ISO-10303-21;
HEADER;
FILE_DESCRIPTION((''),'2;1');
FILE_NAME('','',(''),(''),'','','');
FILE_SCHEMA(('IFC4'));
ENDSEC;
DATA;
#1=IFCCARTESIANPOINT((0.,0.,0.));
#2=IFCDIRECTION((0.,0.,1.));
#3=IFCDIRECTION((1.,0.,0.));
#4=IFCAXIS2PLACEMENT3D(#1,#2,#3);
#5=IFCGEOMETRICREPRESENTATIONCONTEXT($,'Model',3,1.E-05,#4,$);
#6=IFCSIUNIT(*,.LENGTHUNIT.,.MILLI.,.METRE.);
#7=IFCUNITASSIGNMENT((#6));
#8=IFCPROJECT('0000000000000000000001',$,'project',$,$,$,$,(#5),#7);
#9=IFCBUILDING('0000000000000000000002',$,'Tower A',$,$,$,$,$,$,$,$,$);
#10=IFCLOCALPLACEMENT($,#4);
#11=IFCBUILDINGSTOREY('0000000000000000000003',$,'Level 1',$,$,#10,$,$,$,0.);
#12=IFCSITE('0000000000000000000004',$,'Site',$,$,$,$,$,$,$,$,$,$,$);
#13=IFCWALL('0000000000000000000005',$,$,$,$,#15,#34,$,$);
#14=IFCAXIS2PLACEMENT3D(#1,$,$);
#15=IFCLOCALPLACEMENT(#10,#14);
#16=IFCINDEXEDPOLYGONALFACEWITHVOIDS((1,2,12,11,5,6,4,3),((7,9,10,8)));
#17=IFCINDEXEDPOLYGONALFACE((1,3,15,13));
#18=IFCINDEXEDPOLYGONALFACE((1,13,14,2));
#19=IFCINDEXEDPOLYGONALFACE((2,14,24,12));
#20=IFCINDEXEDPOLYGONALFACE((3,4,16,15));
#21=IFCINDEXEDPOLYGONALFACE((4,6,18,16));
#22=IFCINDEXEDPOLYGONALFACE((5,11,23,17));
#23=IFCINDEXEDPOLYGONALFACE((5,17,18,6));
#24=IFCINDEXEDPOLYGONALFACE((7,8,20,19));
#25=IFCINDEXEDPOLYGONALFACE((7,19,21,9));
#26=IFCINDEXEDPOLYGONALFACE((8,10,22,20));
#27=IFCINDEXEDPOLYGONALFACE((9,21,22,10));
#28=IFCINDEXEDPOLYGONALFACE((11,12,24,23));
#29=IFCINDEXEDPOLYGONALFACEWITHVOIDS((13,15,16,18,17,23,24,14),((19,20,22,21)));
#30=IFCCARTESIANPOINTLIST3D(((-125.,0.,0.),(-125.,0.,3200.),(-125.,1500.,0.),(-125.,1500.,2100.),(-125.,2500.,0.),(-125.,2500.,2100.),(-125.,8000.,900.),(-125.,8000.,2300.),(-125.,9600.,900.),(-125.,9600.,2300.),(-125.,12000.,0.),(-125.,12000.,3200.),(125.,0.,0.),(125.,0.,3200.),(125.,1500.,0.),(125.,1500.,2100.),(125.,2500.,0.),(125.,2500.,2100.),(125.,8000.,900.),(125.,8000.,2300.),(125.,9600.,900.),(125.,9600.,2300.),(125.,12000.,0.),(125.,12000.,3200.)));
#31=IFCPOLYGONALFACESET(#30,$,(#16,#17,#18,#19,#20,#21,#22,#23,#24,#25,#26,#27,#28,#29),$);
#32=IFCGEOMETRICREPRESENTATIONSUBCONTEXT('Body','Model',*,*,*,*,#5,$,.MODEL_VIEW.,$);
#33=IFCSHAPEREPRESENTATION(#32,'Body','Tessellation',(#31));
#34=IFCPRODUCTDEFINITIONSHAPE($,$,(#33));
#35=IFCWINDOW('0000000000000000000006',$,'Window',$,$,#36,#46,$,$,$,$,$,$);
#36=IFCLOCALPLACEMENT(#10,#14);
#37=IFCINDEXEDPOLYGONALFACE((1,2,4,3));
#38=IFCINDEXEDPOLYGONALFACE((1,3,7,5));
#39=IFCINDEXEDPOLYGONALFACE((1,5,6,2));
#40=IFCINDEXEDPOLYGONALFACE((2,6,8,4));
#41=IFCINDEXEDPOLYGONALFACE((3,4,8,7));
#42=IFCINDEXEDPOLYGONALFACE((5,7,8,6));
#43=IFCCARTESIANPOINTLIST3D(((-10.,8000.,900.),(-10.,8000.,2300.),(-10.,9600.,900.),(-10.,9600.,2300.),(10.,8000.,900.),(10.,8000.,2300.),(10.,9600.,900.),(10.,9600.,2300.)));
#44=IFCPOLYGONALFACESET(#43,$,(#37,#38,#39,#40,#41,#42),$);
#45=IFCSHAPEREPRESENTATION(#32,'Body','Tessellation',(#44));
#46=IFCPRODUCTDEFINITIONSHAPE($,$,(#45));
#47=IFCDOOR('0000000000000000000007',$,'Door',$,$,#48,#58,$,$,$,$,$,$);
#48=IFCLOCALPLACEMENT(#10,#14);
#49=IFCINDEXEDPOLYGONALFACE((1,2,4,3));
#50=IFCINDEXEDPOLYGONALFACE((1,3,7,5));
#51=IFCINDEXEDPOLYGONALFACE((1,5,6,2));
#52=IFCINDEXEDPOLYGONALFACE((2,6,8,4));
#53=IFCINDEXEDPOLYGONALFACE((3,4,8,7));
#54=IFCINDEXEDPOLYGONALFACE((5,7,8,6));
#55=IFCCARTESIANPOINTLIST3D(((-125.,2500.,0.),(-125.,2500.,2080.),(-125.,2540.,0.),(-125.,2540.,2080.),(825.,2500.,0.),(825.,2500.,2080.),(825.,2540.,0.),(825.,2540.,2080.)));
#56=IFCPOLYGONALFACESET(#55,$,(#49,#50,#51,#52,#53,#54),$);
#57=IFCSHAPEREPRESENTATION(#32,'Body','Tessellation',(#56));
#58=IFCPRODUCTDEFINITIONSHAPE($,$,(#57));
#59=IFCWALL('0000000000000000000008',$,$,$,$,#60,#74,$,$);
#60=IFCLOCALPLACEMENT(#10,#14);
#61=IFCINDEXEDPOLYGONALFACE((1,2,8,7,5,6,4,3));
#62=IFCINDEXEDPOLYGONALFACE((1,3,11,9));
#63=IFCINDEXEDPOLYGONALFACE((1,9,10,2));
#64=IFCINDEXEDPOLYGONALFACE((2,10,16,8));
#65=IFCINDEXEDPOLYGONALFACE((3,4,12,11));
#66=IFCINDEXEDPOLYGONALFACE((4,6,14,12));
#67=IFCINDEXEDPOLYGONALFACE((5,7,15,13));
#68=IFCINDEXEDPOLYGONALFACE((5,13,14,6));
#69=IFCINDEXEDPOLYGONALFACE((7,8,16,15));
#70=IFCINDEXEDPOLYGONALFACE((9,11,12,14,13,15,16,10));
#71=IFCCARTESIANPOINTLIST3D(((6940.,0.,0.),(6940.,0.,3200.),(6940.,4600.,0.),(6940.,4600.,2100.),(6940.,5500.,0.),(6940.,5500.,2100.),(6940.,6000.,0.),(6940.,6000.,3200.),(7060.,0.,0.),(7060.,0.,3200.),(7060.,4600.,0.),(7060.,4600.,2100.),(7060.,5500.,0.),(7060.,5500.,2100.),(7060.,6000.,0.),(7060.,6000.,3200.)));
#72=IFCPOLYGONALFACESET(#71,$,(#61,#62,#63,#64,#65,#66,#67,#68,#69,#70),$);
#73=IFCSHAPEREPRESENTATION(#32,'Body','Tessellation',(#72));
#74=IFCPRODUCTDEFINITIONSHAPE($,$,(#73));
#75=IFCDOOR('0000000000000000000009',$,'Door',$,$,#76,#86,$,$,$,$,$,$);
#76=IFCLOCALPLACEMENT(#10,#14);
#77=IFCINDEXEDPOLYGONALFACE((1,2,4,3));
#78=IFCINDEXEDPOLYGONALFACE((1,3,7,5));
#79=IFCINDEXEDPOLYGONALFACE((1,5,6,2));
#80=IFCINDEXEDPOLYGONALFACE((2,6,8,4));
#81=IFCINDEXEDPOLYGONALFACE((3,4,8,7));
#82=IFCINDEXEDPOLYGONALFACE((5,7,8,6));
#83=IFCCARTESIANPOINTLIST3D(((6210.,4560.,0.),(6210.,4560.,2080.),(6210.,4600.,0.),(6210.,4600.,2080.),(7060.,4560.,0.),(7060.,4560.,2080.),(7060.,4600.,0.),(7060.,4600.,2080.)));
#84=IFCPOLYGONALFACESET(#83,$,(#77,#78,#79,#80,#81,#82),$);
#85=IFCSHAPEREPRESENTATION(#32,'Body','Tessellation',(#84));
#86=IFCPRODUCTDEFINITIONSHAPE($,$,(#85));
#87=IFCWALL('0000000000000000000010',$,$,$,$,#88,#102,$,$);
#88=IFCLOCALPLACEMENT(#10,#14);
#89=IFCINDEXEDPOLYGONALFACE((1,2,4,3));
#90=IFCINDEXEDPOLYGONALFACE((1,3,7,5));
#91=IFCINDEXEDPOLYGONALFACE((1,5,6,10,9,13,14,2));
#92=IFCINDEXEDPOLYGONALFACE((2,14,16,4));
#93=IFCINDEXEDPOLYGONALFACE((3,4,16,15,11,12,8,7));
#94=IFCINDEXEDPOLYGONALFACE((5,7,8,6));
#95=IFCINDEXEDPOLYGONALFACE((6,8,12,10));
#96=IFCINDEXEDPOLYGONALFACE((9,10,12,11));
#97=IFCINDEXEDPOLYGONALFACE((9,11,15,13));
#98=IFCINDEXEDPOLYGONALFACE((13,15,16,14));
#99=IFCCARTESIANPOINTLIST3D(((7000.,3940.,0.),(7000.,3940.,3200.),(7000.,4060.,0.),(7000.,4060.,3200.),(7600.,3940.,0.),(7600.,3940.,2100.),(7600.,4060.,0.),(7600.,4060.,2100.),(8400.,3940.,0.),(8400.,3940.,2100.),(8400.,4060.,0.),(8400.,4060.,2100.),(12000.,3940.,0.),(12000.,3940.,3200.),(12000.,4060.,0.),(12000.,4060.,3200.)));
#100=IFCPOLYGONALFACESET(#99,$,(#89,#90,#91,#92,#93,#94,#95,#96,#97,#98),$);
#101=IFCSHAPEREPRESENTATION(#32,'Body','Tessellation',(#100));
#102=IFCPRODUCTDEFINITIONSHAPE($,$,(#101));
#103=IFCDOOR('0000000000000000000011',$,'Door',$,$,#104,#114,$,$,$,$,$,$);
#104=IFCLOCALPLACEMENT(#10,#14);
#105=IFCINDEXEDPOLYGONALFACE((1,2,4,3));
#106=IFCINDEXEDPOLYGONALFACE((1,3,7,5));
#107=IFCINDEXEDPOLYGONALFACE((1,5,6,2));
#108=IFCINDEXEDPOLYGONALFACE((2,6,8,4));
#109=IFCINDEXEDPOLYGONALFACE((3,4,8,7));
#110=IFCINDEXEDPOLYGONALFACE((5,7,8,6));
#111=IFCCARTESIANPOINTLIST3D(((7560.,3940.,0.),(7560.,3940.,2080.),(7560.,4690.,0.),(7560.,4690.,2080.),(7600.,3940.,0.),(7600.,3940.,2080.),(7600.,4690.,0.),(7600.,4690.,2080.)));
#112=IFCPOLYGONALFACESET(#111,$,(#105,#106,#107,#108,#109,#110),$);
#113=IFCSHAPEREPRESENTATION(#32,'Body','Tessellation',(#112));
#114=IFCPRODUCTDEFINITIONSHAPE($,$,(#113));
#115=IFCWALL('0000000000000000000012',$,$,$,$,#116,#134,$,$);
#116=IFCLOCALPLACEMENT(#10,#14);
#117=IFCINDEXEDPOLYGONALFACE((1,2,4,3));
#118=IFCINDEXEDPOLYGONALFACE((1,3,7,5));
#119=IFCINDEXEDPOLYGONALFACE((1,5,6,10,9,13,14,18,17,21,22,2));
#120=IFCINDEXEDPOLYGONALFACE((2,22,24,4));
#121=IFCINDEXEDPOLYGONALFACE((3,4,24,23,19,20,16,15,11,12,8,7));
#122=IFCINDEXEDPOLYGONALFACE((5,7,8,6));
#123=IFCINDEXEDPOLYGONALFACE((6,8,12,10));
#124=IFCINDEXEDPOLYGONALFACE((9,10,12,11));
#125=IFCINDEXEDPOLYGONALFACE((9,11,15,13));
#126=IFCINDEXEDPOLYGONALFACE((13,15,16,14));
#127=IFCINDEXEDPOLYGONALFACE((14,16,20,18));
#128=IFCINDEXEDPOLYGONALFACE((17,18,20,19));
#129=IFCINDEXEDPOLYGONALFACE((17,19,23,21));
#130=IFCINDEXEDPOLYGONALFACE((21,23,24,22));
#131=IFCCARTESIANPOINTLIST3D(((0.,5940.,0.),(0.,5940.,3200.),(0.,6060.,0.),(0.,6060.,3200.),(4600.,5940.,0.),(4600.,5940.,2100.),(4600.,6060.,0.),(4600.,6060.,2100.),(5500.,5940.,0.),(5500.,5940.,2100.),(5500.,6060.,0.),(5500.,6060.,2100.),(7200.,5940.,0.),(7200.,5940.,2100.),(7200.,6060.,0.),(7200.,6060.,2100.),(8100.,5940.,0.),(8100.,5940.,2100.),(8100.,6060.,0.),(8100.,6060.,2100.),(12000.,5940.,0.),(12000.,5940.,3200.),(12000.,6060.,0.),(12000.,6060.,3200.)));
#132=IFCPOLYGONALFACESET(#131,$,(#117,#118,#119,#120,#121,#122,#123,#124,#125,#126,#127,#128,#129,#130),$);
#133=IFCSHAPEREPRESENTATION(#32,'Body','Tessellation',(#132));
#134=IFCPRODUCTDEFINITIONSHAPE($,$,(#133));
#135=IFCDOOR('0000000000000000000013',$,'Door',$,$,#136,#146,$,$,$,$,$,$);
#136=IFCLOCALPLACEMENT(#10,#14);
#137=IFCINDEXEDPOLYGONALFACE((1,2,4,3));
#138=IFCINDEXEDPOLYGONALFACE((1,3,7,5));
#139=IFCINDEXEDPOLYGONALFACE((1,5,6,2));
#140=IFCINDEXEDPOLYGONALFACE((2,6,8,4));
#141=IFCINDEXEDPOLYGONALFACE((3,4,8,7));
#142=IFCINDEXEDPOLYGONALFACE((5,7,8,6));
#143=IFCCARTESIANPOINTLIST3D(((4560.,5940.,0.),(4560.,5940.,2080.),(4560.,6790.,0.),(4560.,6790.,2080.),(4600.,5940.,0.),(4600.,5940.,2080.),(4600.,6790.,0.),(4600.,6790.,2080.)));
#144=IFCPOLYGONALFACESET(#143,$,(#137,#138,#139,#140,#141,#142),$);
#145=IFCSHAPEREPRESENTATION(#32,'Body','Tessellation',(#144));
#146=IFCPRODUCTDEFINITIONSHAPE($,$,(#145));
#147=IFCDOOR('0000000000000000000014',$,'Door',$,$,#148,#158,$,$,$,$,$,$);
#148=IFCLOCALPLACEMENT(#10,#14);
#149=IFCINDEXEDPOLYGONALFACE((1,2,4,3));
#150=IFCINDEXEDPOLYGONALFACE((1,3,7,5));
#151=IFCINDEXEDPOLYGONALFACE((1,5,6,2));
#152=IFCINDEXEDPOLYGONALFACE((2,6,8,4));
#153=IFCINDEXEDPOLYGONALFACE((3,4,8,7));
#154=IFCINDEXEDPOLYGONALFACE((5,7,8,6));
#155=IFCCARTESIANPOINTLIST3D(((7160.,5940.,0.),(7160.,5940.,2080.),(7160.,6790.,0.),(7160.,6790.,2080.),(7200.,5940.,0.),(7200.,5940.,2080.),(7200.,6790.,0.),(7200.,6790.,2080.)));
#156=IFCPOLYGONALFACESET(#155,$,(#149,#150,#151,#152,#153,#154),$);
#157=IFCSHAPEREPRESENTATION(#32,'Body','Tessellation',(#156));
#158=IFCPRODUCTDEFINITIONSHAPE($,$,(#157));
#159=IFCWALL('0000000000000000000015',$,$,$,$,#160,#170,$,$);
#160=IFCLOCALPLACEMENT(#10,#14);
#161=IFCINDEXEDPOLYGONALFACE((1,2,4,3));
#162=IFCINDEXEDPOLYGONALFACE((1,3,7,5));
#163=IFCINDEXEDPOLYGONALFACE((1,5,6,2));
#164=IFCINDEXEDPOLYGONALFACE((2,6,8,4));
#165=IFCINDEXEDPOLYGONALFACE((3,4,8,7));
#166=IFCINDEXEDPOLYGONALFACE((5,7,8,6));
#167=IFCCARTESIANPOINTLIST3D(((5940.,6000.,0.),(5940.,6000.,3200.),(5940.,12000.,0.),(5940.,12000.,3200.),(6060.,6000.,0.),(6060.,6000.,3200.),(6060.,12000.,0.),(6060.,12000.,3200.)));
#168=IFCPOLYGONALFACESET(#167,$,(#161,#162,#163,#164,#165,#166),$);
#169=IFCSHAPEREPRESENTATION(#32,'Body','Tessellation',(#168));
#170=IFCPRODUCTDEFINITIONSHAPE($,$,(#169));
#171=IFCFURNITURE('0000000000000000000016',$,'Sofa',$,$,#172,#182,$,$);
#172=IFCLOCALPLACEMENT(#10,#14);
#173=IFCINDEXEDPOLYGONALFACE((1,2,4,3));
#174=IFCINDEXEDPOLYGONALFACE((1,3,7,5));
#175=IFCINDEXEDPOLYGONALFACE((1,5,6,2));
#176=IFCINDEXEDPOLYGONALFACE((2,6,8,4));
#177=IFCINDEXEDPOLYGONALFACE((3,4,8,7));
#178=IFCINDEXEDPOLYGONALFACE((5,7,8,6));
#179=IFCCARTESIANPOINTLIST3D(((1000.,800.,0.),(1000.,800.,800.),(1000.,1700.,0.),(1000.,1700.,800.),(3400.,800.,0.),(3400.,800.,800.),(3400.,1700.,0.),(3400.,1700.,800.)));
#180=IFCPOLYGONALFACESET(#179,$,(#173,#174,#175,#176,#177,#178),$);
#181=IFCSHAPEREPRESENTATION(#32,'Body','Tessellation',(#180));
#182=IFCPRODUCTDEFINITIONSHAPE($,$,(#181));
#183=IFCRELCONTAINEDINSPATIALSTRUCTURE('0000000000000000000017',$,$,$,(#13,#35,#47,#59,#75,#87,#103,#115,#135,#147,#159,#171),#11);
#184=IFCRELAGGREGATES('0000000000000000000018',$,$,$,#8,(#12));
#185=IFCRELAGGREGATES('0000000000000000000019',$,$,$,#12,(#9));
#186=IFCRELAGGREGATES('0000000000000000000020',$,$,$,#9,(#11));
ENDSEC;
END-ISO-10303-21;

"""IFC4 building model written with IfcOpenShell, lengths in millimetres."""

from ifc_helpers import new_model, si_unit, frame, origin_with_axes, place, context, subcontext, project, spatial, indexed_curve, outline, extrude, element, fill, save


model = new_model("IFC4")

# Units and contexts
model_context = context("Model", 3, precision=1e-05, world=origin_with_axes())
body_context = subcontext(model_context, "Body", "Model", "MODEL_VIEW")
ifc_project = project(units=[si_unit("LENGTHUNIT", "METRE", prefix="MILLI")], contexts=[model_context])

# Site, building, storey
site = spatial("IfcSite", under=ifc_project, Name="Site")
building = spatial("IfcBuilding", under=site, Name="Tower A")
storey_placement = place(None, origin_with_axes())
storey = spatial("IfcBuildingStorey", under=building, at=storey_placement, Name="Level 1", Elevation=0.0)

# Wall, openings, window, door
wall_1_placement = place(storey_placement, frame((-125.0, 12000.0, 0.0), z_axis=(0.0, 0.0, 1.0), x_axis=(0.0, -1.0, 0.0)))
wall_1 = element("IfcWall", 1, at=wall_1_placement, inside=storey, context=body_context, shape_type="SweptSolid", body=[
    extrude(outline(indexed_curve([(0.0, 0.0), (0.0, 250.0), (12000.0, 250.0), (12000.0, 0.0), (0.0, 0.0)], self_intersect=False)), origin_with_axes(), (0.0, 0.0, 1.0), 3200.0),
])
opening_1_placement = place(wall_1_placement, frame((2400.0, 0.0, 900.0), z_axis=(0.0, 0.0, 1.0), x_axis=(1.0, 0.0, 0.0)))
opening_1 = element("IfcOpeningElement", 2, at=opening_1_placement, cuts=wall_1, context=body_context, shape_type="SweptSolid", body=[
    extrude(outline(indexed_curve([(0.0, 0.0), (0.0, 250.0), (1600.0, 250.0), (1600.0, 0.0), (0.0, 0.0)], self_intersect=False)), origin_with_axes(), (0.0, 0.0, 1.0), 1400.0),
])
opening_2_placement = place(wall_1_placement, frame((9500.0, 0.0, 0.0), z_axis=(0.0, 0.0, 1.0), x_axis=(1.0, 0.0, 0.0)))
opening_2 = element("IfcOpeningElement", 3, at=opening_2_placement, cuts=wall_1, context=body_context, shape_type="SweptSolid", body=[
    extrude(outline(indexed_curve([(0.0, 0.0), (0.0, 250.0), (1000.0, 250.0), (1000.0, 0.0), (0.0, 0.0)], self_intersect=False)), origin_with_axes(), (0.0, 0.0, 1.0), 2100.0),
])
window_1_placement = place(storey_placement, frame((-10.0, 9600.0, 900.0), z_axis=(0.0, 0.0, 1.0), x_axis=(0.0, -1.0, 0.0)))
window_1 = element("IfcWindow", 4, at=window_1_placement, inside=storey, Name="Window", context=body_context, shape_type="SweptSolid", body=[
    extrude(outline(indexed_curve([(0.0, 0.0), (0.0, 20.0), (1600.0, 20.0), (1600.0, 0.0), (0.0, 0.0)], self_intersect=False)), origin_with_axes(), (0.0, 0.0, 1.0), 1400.0),
])
fill(opening_1, window_1)
door_1_placement = place(storey_placement, frame((-125.0, 2500.0, 0.0), z_axis=(0.0, 0.0, 1.0), x_axis=(1.0, 0.0, 0.0)))
door_1 = element("IfcDoor", 5, at=door_1_placement, inside=storey, Name="Door", context=body_context, shape_type="SweptSolid", body=[
    extrude(outline(indexed_curve([(0.0, 0.0), (0.0, 40.0), (950.0, 40.0), (950.0, 0.0), (0.0, 0.0)], self_intersect=False)), origin_with_axes(), (0.0, 0.0, 1.0), 2080.0),
])
fill(opening_2, door_1)

# Walls, openings, doors
wall_2_placement = place(storey_placement, frame((7060.0, 0.0, 0.0), z_axis=(0.0, 0.0, 1.0), x_axis=(0.0, 1.0, 0.0)))
wall_2 = element("IfcWall", 6, at=wall_2_placement, inside=storey, context=body_context, shape_type="SweptSolid", body=[
    extrude(outline(indexed_curve([(0.0, 0.0), (0.0, 120.0), (6000.0, 120.0), (6000.0, 0.0), (0.0, 0.0)], self_intersect=False)), origin_with_axes(), (0.0, 0.0, 1.0), 3200.0),
])
opening_3_placement = place(wall_2_placement, frame((4600.0, 0.0, 0.0), z_axis=(0.0, 0.0, 1.0), x_axis=(1.0, 0.0, 0.0)))
opening_3 = element("IfcOpeningElement", 7, at=opening_3_placement, cuts=wall_2, context=body_context, shape_type="SweptSolid", body=[
    extrude(outline(indexed_curve([(0.0, 0.0), (0.0, 120.0), (900.0, 120.0), (900.0, 0.0), (0.0, 0.0)], self_intersect=False)), origin_with_axes(), (0.0, 0.0, 1.0), 2100.0),
])
door_2_placement = place(storey_placement, frame((7060.0, 4600.0, 0.0), z_axis=(0.0, 0.0, 1.0), x_axis=(-1.0, 0.0, 0.0)))
door_2 = element("IfcDoor", 8, at=door_2_placement, inside=storey, Name="Door", context=body_context, shape_type="SweptSolid", body=[
    extrude(outline(indexed_curve([(0.0, 0.0), (0.0, 40.0), (850.0, 40.0), (850.0, 0.0), (0.0, 0.0)], self_intersect=False)), origin_with_axes(), (0.0, 0.0, 1.0), 2080.0),
])
fill(opening_3, door_2)
wall_3_placement = place(storey_placement, frame((7000.0, 3940.0, 0.0), z_axis=(0.0, 0.0, 1.0), x_axis=(1.0, 0.0, 0.0)))
wall_3 = element("IfcWall", 9, at=wall_3_placement, inside=storey, context=body_context, shape_type="SweptSolid", body=[
    extrude(outline(indexed_curve([(0.0, 0.0), (0.0, 120.0), (5000.0, 120.0), (5000.0, 0.0), (0.0, 0.0)], self_intersect=False)), origin_with_axes(), (0.0, 0.0, 1.0), 3200.0),
])
opening_4_placement = place(wall_3_placement, frame((600.0, 0.0, 0.0), z_axis=(0.0, 0.0, 1.0), x_axis=(1.0, 0.0, 0.0)))
opening_4 = element("IfcOpeningElement", 10, at=opening_4_placement, cuts=wall_3, context=body_context, shape_type="SweptSolid", body=[
    extrude(outline(indexed_curve([(0.0, 0.0), (0.0, 120.0), (800.0, 120.0), (800.0, 0.0), (0.0, 0.0)], self_intersect=False)), origin_with_axes(), (0.0, 0.0, 1.0), 2100.0),
])
door_3_placement = place(storey_placement, frame((7600.0, 3940.0, 0.0), z_axis=(0.0, 0.0, 1.0), x_axis=(0.0, 1.0, 0.0)))
door_3 = element("IfcDoor", 11, at=door_3_placement, inside=storey, Name="Door", context=body_context, shape_type="SweptSolid", body=[
    extrude(outline(indexed_curve([(0.0, 0.0), (0.0, 40.0), (750.0, 40.0), (750.0, 0.0), (0.0, 0.0)], self_intersect=False)), origin_with_axes(), (0.0, 0.0, 1.0), 2080.0),
])
fill(opening_4, door_3)

# Wall, openings, doors
wall_4_placement = place(storey_placement, frame((0.0, 5940.0, 0.0), z_axis=(0.0, 0.0, 1.0), x_axis=(1.0, 0.0, 0.0)))
wall_4 = element("IfcWall", 12, at=wall_4_placement, inside=storey, context=body_context, shape_type="SweptSolid", body=[
    extrude(outline(indexed_curve([(0.0, 0.0), (0.0, 120.0), (12000.0, 120.0), (12000.0, 0.0), (0.0, 0.0)], self_intersect=False)), origin_with_axes(), (0.0, 0.0, 1.0), 3200.0),
])
opening_5_placement = place(wall_4_placement, frame((4600.0, 0.0, 0.0), z_axis=(0.0, 0.0, 1.0), x_axis=(1.0, 0.0, 0.0)))
opening_5 = element("IfcOpeningElement", 13, at=opening_5_placement, cuts=wall_4, context=body_context, shape_type="SweptSolid", body=[
    extrude(outline(indexed_curve([(0.0, 0.0), (0.0, 120.0), (900.0, 120.0), (900.0, 0.0), (0.0, 0.0)], self_intersect=False)), origin_with_axes(), (0.0, 0.0, 1.0), 2100.0),
])
opening_6_placement = place(wall_4_placement, frame((7200.0, 0.0, 0.0), z_axis=(0.0, 0.0, 1.0), x_axis=(1.0, 0.0, 0.0)))
opening_6 = element("IfcOpeningElement", 14, at=opening_6_placement, cuts=wall_4, context=body_context, shape_type="SweptSolid", body=[
    extrude(outline(indexed_curve([(0.0, 0.0), (0.0, 120.0), (900.0, 120.0), (900.0, 0.0), (0.0, 0.0)], self_intersect=False)), origin_with_axes(), (0.0, 0.0, 1.0), 2100.0),
])
door_4_placement = place(storey_placement, frame((4600.0, 5940.0, 0.0), z_axis=(0.0, 0.0, 1.0), x_axis=(0.0, 1.0, 0.0)))
door_4 = element("IfcDoor", 15, at=door_4_placement, inside=storey, Name="Door", context=body_context, shape_type="SweptSolid", body=[
    extrude(outline(indexed_curve([(0.0, 0.0), (0.0, 40.0), (850.0, 40.0), (850.0, 0.0), (0.0, 0.0)], self_intersect=False)), origin_with_axes(), (0.0, 0.0, 1.0), 2080.0),
])
fill(opening_5, door_4)
door_5_placement = place(storey_placement, frame((7200.0, 5940.0, 0.0), z_axis=(0.0, 0.0, 1.0), x_axis=(0.0, 1.0, 0.0)))
door_5 = element("IfcDoor", 16, at=door_5_placement, inside=storey, Name="Door", context=body_context, shape_type="SweptSolid", body=[
    extrude(outline(indexed_curve([(0.0, 0.0), (0.0, 40.0), (850.0, 40.0), (850.0, 0.0), (0.0, 0.0)], self_intersect=False)), origin_with_axes(), (0.0, 0.0, 1.0), 2080.0),
])
fill(opening_6, door_5)

# Wall
wall_5_placement = place(storey_placement, frame((6060.0, 6000.0, 0.0), z_axis=(0.0, 0.0, 1.0), x_axis=(0.0, 1.0, 0.0)))
element("IfcWall", 17, at=wall_5_placement, inside=storey, context=body_context, shape_type="SweptSolid", body=[
    extrude(outline(indexed_curve([(0.0, 0.0), (0.0, 120.0), (6000.0, 120.0), (6000.0, 0.0), (0.0, 0.0)], self_intersect=False)), origin_with_axes(), (0.0, 0.0, 1.0), 3200.0),
])

# Furniture
furniture_1_placement = place(storey_placement, frame((1000.0, 800.0, 0.0), z_axis=(0.0, 0.0, 1.0), x_axis=(1.0, 0.0, 0.0)))
element("IfcFurniture", 18, at=furniture_1_placement, inside=storey, Name="Sofa", context=body_context, shape_type="SweptSolid", body=[
    extrude(outline(indexed_curve([(0.0, 0.0), (2400.0, 0.0), (2400.0, 900.0), (0.0, 900.0)])), None, (0.0, 0.0, 1.0), 800.0),
])

save(model, "model.ifc")
